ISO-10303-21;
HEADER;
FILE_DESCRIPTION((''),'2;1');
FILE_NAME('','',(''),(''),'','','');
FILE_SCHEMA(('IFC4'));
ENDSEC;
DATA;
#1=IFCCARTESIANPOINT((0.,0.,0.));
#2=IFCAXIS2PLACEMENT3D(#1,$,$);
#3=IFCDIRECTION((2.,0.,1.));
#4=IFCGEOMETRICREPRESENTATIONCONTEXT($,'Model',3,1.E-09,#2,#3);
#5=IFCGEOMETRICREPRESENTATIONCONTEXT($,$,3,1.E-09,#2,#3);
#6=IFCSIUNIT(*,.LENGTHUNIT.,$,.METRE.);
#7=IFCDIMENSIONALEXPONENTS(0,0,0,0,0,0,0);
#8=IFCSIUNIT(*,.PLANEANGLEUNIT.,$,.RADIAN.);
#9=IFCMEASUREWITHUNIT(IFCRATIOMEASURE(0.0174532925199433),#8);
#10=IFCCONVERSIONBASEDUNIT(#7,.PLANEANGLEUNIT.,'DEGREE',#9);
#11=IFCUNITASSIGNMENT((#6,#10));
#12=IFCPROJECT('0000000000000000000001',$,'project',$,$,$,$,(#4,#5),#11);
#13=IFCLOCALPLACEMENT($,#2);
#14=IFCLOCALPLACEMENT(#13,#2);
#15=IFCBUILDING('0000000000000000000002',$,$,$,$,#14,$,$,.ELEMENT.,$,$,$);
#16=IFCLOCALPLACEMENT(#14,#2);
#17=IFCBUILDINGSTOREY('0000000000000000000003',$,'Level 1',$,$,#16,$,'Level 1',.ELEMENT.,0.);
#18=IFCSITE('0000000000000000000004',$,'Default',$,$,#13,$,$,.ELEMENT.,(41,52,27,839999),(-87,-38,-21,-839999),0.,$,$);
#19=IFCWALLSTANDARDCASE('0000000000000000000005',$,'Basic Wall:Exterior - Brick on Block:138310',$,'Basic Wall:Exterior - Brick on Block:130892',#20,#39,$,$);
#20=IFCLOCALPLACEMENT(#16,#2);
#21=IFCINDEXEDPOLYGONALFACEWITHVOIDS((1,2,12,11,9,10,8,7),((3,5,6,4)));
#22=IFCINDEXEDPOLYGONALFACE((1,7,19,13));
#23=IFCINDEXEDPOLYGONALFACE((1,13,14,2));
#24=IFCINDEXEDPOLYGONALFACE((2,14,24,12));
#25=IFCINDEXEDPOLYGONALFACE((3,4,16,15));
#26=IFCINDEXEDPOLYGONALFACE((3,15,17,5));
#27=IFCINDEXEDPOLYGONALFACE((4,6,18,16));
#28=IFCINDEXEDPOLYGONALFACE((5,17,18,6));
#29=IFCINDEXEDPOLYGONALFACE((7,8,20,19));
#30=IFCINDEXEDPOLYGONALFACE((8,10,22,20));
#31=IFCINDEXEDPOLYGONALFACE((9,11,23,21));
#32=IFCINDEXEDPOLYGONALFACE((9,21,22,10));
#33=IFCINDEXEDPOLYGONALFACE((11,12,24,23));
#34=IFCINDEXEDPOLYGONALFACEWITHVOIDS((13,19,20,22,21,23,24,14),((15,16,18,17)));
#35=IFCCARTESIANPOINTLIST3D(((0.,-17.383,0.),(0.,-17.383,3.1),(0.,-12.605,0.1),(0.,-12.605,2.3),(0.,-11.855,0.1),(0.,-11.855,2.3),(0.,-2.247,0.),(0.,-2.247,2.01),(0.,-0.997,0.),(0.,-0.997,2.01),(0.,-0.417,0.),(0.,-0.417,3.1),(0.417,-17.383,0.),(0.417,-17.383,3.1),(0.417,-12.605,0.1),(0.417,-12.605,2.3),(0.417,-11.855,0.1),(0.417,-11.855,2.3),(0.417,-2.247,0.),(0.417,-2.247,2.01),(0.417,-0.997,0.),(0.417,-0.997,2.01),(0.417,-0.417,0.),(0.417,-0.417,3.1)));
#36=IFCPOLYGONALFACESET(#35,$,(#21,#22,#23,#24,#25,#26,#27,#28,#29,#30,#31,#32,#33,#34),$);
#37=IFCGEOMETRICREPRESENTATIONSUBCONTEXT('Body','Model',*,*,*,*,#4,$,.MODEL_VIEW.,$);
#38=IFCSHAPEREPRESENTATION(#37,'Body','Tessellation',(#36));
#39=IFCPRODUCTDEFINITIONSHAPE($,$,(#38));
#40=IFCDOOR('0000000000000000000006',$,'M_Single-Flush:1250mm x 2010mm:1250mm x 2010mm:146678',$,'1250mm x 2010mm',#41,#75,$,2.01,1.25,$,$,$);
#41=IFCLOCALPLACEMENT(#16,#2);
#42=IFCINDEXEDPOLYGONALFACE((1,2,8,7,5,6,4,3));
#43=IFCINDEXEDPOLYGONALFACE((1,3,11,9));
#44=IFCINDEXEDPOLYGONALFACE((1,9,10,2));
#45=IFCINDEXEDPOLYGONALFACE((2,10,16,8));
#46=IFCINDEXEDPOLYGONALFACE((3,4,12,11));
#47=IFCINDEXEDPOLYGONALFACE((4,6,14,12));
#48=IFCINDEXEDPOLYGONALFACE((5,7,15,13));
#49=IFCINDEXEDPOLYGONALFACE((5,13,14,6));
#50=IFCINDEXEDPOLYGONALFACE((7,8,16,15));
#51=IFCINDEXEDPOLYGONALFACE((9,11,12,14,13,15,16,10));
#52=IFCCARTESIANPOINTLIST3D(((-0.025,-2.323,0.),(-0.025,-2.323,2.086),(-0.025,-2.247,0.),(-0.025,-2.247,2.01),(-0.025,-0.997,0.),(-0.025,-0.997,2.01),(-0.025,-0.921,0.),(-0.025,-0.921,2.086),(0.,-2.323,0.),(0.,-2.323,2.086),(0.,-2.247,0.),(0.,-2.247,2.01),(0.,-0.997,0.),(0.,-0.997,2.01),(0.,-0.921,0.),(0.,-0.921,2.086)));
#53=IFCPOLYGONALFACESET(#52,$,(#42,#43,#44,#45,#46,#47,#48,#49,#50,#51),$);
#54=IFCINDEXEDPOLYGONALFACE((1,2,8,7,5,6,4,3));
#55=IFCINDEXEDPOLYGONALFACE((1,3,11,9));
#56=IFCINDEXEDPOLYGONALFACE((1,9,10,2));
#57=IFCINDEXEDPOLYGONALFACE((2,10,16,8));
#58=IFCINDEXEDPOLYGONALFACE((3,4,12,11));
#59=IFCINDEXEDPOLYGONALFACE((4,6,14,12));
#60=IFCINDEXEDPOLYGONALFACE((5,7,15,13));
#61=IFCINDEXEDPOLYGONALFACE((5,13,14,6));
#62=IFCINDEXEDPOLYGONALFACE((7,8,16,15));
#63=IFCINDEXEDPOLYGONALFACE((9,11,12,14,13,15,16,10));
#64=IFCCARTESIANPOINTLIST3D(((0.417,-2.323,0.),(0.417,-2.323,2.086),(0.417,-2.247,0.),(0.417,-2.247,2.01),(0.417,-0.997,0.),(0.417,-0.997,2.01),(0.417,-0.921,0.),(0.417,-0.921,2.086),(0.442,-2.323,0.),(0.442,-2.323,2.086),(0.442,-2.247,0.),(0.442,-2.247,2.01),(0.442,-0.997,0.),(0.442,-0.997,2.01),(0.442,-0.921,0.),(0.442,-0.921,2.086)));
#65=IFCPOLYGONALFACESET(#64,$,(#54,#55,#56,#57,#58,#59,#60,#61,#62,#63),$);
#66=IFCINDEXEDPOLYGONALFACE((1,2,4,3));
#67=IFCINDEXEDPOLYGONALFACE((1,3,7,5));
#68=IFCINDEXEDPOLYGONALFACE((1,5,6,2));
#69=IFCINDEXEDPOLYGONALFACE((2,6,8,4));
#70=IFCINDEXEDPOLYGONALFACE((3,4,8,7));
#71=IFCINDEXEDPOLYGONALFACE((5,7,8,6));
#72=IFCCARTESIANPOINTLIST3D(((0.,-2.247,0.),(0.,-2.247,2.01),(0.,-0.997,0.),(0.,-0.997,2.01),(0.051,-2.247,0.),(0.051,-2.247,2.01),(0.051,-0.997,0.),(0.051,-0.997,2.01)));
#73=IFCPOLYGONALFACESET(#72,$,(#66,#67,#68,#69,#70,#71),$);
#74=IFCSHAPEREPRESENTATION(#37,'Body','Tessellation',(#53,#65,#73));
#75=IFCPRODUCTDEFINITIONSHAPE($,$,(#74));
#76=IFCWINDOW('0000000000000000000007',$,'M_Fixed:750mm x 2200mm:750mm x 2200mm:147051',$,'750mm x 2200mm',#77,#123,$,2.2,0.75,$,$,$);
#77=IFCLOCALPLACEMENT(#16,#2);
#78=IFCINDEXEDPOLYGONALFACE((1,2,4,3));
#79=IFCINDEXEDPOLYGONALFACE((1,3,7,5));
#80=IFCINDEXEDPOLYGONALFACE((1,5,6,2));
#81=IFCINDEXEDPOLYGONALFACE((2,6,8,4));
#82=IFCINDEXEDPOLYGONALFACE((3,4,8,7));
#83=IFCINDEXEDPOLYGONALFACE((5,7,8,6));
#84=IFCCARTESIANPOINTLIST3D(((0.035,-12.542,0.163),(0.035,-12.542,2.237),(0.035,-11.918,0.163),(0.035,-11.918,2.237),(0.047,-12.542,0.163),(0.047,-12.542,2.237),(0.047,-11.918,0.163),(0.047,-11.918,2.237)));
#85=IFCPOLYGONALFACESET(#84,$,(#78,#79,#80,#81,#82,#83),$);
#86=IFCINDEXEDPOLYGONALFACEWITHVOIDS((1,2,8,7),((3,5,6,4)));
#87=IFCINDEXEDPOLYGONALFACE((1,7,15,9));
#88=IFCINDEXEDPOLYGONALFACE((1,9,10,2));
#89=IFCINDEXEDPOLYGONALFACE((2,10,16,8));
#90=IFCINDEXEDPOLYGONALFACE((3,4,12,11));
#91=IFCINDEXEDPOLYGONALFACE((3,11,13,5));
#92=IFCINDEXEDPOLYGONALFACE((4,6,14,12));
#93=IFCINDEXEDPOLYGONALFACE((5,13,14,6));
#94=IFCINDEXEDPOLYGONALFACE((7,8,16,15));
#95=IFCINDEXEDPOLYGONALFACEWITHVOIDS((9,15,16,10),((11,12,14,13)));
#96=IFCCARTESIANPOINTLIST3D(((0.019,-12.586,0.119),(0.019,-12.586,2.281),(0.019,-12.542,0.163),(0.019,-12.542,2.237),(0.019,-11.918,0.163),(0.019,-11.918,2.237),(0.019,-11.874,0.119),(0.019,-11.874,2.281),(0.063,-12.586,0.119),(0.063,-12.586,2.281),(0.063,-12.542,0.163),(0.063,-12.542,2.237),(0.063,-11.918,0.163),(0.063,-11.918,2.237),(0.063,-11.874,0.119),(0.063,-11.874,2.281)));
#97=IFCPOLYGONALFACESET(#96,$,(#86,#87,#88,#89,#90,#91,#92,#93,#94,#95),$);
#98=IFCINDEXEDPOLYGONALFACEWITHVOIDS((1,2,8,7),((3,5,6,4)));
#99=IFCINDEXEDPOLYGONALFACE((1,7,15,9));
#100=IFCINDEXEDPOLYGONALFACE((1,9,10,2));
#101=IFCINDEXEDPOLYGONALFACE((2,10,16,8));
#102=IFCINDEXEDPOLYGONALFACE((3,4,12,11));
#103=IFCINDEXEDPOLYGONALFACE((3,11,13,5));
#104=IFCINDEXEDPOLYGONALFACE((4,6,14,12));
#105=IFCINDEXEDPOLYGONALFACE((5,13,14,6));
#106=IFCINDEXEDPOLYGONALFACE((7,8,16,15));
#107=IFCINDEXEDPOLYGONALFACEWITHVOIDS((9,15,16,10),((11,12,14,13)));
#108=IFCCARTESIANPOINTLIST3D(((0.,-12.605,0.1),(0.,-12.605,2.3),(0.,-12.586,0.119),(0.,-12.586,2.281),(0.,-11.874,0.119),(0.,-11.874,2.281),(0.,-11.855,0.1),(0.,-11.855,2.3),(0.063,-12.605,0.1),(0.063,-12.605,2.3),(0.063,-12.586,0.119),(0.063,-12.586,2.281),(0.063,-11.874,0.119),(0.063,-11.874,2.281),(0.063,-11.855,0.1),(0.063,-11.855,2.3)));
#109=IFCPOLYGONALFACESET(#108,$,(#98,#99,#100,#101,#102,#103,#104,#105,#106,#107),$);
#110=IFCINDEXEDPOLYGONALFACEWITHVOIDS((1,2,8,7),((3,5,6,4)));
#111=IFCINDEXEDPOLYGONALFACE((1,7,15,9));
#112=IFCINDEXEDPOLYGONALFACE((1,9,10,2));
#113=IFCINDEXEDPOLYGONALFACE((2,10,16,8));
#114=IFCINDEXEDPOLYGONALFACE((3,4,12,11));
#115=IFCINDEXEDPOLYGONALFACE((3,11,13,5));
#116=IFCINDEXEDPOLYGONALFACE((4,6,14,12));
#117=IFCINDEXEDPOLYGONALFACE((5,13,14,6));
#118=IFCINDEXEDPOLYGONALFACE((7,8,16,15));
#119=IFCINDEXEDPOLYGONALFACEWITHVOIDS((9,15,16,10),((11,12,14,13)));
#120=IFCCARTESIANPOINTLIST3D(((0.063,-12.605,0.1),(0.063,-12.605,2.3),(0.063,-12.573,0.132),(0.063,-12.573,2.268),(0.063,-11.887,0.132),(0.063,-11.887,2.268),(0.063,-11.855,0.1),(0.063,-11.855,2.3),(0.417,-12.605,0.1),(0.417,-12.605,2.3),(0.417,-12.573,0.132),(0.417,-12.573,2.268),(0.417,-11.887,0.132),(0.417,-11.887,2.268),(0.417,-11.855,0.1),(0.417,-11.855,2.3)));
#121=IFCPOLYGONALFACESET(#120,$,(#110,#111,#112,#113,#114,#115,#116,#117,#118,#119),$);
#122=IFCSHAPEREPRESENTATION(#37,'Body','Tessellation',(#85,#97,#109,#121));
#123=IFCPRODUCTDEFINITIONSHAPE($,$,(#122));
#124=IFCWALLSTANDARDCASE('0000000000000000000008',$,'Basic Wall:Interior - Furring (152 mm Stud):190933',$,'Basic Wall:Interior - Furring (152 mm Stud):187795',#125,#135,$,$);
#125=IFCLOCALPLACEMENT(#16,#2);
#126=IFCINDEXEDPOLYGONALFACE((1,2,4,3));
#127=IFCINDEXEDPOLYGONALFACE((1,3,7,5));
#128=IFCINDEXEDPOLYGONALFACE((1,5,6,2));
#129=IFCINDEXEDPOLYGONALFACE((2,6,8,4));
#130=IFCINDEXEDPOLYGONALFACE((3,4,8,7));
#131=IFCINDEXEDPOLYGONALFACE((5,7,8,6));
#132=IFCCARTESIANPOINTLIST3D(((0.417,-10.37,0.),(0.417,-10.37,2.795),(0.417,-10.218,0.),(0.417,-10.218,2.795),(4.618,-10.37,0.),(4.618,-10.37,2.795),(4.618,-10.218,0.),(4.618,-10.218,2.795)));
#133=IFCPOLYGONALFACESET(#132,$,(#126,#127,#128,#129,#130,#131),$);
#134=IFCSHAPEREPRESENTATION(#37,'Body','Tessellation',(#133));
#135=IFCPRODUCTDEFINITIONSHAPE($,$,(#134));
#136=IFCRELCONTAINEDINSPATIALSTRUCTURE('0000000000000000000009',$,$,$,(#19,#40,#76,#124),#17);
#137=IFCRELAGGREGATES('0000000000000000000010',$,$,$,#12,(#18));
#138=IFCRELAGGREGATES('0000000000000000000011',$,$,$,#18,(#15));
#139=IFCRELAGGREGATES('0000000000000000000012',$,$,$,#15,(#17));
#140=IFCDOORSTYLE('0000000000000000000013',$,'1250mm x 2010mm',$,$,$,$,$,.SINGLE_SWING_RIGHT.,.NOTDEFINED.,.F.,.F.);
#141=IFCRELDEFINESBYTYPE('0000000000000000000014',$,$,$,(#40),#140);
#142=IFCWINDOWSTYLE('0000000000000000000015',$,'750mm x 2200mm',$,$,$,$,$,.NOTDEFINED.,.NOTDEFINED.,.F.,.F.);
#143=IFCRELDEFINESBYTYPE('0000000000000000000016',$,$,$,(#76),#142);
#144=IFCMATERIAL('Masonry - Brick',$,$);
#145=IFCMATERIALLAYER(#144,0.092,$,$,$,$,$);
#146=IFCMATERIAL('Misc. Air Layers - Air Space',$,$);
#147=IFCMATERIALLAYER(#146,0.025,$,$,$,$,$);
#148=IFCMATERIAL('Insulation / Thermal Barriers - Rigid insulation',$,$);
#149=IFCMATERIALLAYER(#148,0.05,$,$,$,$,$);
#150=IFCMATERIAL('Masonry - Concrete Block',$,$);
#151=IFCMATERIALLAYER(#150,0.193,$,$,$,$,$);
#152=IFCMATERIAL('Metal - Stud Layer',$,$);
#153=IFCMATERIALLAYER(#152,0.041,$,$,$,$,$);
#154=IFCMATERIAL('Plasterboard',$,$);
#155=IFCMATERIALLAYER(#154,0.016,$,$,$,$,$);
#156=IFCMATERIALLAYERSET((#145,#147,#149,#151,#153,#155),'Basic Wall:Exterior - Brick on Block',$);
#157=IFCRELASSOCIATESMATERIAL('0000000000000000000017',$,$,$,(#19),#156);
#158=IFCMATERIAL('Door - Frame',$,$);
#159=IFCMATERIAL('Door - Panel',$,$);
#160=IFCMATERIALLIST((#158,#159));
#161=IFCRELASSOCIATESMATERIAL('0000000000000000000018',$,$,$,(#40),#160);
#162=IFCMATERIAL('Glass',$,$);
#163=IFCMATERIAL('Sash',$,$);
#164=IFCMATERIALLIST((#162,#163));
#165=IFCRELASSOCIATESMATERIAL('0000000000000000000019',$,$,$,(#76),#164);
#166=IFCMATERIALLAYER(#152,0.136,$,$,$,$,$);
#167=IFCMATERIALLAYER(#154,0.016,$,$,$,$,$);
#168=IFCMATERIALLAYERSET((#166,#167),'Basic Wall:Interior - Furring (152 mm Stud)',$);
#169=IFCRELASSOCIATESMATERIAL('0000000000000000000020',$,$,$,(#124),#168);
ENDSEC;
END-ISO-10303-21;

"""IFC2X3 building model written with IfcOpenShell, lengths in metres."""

from ifc_helpers import new_model, entity, si_unit, converted_unit, direction, frame, frame_2d, origin, origin_2d_with_axis, place, context, subcontext, project, spatial, polyline, rectangle, outline, extrude, source, transform, mapped, material, material_list, layer, layer_set, layer_usage, type_object, type_shapes, element, fill, save


model = new_model("IFC2X3")

# Units and contexts
model_context = context("Model", 3, precision=1e-09, world=origin(), true_north=direction((2.0, 0.0, 1.0)))
context_of_model = context(None, 3, precision=1e-09, world=origin(), true_north=direction((2.0, 0.0, 1.0)))
body_context = subcontext(model_context, "Body", "Model", "MODEL_VIEW")
ifc_project = project(units=[si_unit("LENGTHUNIT", "METRE"), converted_unit("PLANEANGLEUNIT", "DEGREE", entity("IfcRatioMeasure", 0.0174532925199433), si_unit("PLANEANGLEUNIT", "RADIAN"), dimensions=[0, 0, 0, 0, 0, 0, 0])], contexts=[model_context, context_of_model])

# Site, building, storey
site_placement = place(None, origin())
site = spatial("IfcSite", under=ifc_project, at=site_placement, Name="Default", CompositionType="ELEMENT", RefLatitude=(41, 52, 27, 839999), RefLongitude=(-87, -38, -21, -839999), RefElevation=0.0)
building_placement = place(site_placement, origin())
building = spatial("IfcBuilding", under=site, at=building_placement, CompositionType="ELEMENT")
storey_placement = place(building_placement, origin())
storey = spatial("IfcBuildingStorey", under=building, at=storey_placement, Name="Level 1", LongName="Level 1", CompositionType="ELEMENT", Elevation=0.0)

# Wall, openings, door, window
ifc_material_1 = material(Name="Masonry - Brick")
ifc_layer_1 = layer(ifc_material_1, 0.092)
ifc_material_2 = material(Name="Misc. Air Layers - Air Space")
ifc_layer_2 = layer(ifc_material_2, 0.025)
ifc_material_3 = material(Name="Insulation / Thermal Barriers - Rigid insulation")
ifc_layer_3 = layer(ifc_material_3, 0.05)
ifc_material_4 = material(Name="Masonry - Concrete Block")
ifc_layer_4 = layer(ifc_material_4, 0.193)
ifc_material_5 = material(Name="Metal - Stud Layer")
ifc_layer_5 = layer(ifc_material_5, 0.041)
ifc_material_6 = material(Name="Plasterboard")
ifc_layer_6 = layer(ifc_material_6, 0.016)
ifc_layer_set_1 = layer_set([ifc_layer_1, ifc_layer_2, ifc_layer_3, ifc_layer_4, ifc_layer_5, ifc_layer_6], Name="Basic Wall:Exterior - Brick on Block")
ifc_layer_usage_1 = layer_usage(ifc_layer_set_1, "AXIS2", "NEGATIVE", 0.2085)
wall_1_placement = place(storey_placement, frame((0.2085, -17.383, 0.0), z_axis=(0.0, 0.0, 1.0), x_axis=(0.0, 1.0, 0.0)))
wall_1 = element("IfcWallStandardCase", 1, at=wall_1_placement, inside=storey, material=ifc_layer_usage_1, Name="Basic Wall:Exterior - Brick on Block:138310", ObjectType="Basic Wall:Exterior - Brick on Block:130892", context=body_context, shape_type="SweptSolid", body=[
    extrude(rectangle(XDim=16.966, YDim=0.417, at=frame_2d((8.483, 0.0), x_axis=(-1.0, 0.0))), origin(), (0.0, 0.0, 1.0), 3.1),
])
opening_1_placement = place(wall_1_placement, frame((15.136, -0.2085, 0.0)))
opening_1 = element("IfcOpeningElement", 2, at=opening_1_placement, cuts=wall_1, ObjectType="Opening", context=body_context, shape_type="SweptSolid", body=[
    extrude(rectangle(XDim=1.25, YDim=2.01, at=frame_2d((1.005, 0.625), x_axis=(0.0, 1.0))), frame((0.0, 0.0, 0.0), z_axis=(0.0, 1.0, 0.0), x_axis=(0.0, 0.0, 1.0)), (0.0, 0.0, 1.0), 0.417),
])
opening_2_placement = place(wall_1_placement, frame((4.778, -0.2085, 0.1)))
opening_2 = element("IfcOpeningElement", 3, at=opening_2_placement, cuts=wall_1, ObjectType="Opening", context=body_context, shape_type="SweptSolid", body=[
    extrude(rectangle(XDim=2.2, YDim=0.75, at=frame_2d((1.1, 0.375), x_axis=(1.0, 0.0))), frame((0.0, 0.0, 0.0), z_axis=(0.0, 1.0, 0.0), x_axis=(0.0, 0.0, 1.0)), (0.0, 0.0, 1.0), 0.417),
])
ifc_material_7 = material(Name="Door - Frame")
ifc_material_8 = material(Name="Door - Panel")
ifc_material_list_1 = material_list([ifc_material_7, ifc_material_8])
door_style = type_object("IfcDoorStyle", Name="1250mm x 2010mm", ConstructionType="NOTDEFINED", OperationType="SINGLE_SWING_RIGHT", ParameterTakesPrecedence=False, Sizeable=False)
shared_shape_1 = source(origin(), body_context, "Body", "SweptSolid", [
    extrude(outline(polyline([(-0.701, -1.062), (0.701, -1.062), (0.701, 1.024), (0.625, 1.024), (0.625, -0.986), (-0.625, -0.986), (-0.625, 1.024), (-0.701, 1.024), (-0.701, -1.062)])), frame((0.625, 0.417, 1.024), z_axis=(0.0, 1.0, 0.0), x_axis=(1.0, 0.0, 0.0)), (0.0, 0.0, 1.0), 0.025),
    extrude(outline(polyline([(-1.062, -0.701), (1.024, -0.701), (1.024, -0.625), (-0.986, -0.625), (-0.986, 0.625), (1.024, 0.625), (1.024, 0.701), (-1.062, 0.701), (-1.062, -0.701)])), frame((0.625, -0.025, 1.024), z_axis=(0.0, 1.0, 0.0), x_axis=(0.0, 0.0, -1.0)), (0.0, 0.0, 1.0), 0.025),
    extrude(rectangle(XDim=0.051, YDim=1.25, at=frame_2d((0.0, 0.0), x_axis=(1.0, 0.0))), frame((0.625, 0.3915, 0.0), z_axis=(0.0, 0.0, 1.0), x_axis=(0.0, 1.0, 0.0)), (0.0, 0.0, 1.0), 2.01),
])
type_shapes(door_style, [shared_shape_1])
door_placement = place(opening_1_placement, origin())
door = element("IfcDoor", 4, at=door_placement, inside=storey, type_object=door_style, material=ifc_material_list_1, Name="M_Single-Flush:1250mm x 2010mm:1250mm x 2010mm:146678", ObjectType="1250mm x 2010mm", OverallHeight=2.01, OverallWidth=1.25, context=body_context, shape_type="MappedRepresentation", body=[
    mapped(shared_shape_1, transform((0.0, 0.0, 0.0), scale=1.0)),
])
fill(opening_1, door)
ifc_material_9 = material(Name="Glass")
ifc_material_10 = material(Name="Sash")
ifc_material_list_2 = material_list([ifc_material_9, ifc_material_10])
window_style = type_object("IfcWindowStyle", Name="750mm x 2200mm", ConstructionType="NOTDEFINED", OperationType="NOTDEFINED", ParameterTakesPrecedence=False, Sizeable=False)
shared_shape_2 = source(origin(), body_context, "Body", "SweptSolid", [
    extrude(rectangle(XDim=0.012, YDim=0.624, at=origin_2d_with_axis()), frame((0.375, 0.376, 0.063), z_axis=(0.0, 0.0, 1.0), x_axis=(0.0, -1.0, 0.0)), (0.0, 0.0, 1.0), 2.074),
    extrude(outline(polyline([(-0.356, -1.081), (0.356, -1.081), (0.356, 1.081), (-0.356, 1.081), (-0.356, -1.081)]), holes=[polyline([(-0.312, -1.037), (-0.312, 1.037), (0.312, 1.037), (0.312, -1.037), (-0.312, -1.037)])]), frame((0.375, 0.354, 1.1), z_axis=(0.0, 1.0, 0.0), x_axis=(1.0, 0.0, 0.0)), (0.0, 0.0, 1.0), 0.044),
    extrude(outline(polyline([(-0.375, -1.1), (0.375, -1.1), (0.375, 1.1), (-0.375, 1.1), (-0.375, -1.1)]), holes=[polyline([(-0.356, -1.081), (-0.356, 1.081), (0.356, 1.081), (0.356, -1.081), (-0.356, -1.081)])]), frame((0.375, 0.354, 1.1), z_axis=(0.0, 1.0, 0.0), x_axis=(1.0, 0.0, 0.0)), (0.0, 0.0, 1.0), 0.063),
    extrude(outline(polyline([(-0.375, -1.1), (0.375, -1.1), (0.375, 1.1), (-0.375, 1.1), (-0.375, -1.1)]), holes=[polyline([(-0.343, -1.068), (-0.343, 1.068), (0.343, 1.068), (0.343, -1.068), (-0.343, -1.068)])]), frame((0.375, 0.0, 1.1), z_axis=(0.0, 1.0, 0.0), x_axis=(1.0, 0.0, 0.0)), (0.0, 0.0, 1.0), 0.354),
])
type_shapes(window_style, [shared_shape_2])
window_placement = place(opening_2_placement, origin())
window = element("IfcWindow", 5, at=window_placement, inside=storey, type_object=window_style, material=ifc_material_list_2, Name="M_Fixed:750mm x 2200mm:750mm x 2200mm:147051", ObjectType="750mm x 2200mm", OverallHeight=2.2, OverallWidth=0.75, context=body_context, shape_type="MappedRepresentation", body=[
    mapped(shared_shape_2, transform((0.0, 0.0, 0.0), scale=1.0)),
])
fill(opening_2, window)

# Wall
ifc_layer_7 = layer(ifc_material_5, 0.136)
ifc_layer_8 = layer(ifc_material_6, 0.016)
ifc_layer_set_2 = layer_set([ifc_layer_7, ifc_layer_8], Name="Basic Wall:Interior - Furring (152 mm Stud)")
ifc_layer_usage_2 = layer_usage(ifc_layer_set_2, "AXIS2", "NEGATIVE", 0.076)
wall_2_placement = place(storey_placement, frame((0.417, -10.294, 0.0)))
element("IfcWallStandardCase", 6, at=wall_2_placement, inside=storey, material=ifc_layer_usage_2, Name="Basic Wall:Interior - Furring (152 mm Stud):190933", ObjectType="Basic Wall:Interior - Furring (152 mm Stud):187795", context=body_context, shape_type="SweptSolid", body=[
    extrude(rectangle(XDim=4.201, YDim=0.152, at=frame_2d((2.1005, 0.0), x_axis=(-1.0, 0.0))), origin(), (0.0, 0.0, 1.0), 2.795),
])

save(model, "model.ifc")
